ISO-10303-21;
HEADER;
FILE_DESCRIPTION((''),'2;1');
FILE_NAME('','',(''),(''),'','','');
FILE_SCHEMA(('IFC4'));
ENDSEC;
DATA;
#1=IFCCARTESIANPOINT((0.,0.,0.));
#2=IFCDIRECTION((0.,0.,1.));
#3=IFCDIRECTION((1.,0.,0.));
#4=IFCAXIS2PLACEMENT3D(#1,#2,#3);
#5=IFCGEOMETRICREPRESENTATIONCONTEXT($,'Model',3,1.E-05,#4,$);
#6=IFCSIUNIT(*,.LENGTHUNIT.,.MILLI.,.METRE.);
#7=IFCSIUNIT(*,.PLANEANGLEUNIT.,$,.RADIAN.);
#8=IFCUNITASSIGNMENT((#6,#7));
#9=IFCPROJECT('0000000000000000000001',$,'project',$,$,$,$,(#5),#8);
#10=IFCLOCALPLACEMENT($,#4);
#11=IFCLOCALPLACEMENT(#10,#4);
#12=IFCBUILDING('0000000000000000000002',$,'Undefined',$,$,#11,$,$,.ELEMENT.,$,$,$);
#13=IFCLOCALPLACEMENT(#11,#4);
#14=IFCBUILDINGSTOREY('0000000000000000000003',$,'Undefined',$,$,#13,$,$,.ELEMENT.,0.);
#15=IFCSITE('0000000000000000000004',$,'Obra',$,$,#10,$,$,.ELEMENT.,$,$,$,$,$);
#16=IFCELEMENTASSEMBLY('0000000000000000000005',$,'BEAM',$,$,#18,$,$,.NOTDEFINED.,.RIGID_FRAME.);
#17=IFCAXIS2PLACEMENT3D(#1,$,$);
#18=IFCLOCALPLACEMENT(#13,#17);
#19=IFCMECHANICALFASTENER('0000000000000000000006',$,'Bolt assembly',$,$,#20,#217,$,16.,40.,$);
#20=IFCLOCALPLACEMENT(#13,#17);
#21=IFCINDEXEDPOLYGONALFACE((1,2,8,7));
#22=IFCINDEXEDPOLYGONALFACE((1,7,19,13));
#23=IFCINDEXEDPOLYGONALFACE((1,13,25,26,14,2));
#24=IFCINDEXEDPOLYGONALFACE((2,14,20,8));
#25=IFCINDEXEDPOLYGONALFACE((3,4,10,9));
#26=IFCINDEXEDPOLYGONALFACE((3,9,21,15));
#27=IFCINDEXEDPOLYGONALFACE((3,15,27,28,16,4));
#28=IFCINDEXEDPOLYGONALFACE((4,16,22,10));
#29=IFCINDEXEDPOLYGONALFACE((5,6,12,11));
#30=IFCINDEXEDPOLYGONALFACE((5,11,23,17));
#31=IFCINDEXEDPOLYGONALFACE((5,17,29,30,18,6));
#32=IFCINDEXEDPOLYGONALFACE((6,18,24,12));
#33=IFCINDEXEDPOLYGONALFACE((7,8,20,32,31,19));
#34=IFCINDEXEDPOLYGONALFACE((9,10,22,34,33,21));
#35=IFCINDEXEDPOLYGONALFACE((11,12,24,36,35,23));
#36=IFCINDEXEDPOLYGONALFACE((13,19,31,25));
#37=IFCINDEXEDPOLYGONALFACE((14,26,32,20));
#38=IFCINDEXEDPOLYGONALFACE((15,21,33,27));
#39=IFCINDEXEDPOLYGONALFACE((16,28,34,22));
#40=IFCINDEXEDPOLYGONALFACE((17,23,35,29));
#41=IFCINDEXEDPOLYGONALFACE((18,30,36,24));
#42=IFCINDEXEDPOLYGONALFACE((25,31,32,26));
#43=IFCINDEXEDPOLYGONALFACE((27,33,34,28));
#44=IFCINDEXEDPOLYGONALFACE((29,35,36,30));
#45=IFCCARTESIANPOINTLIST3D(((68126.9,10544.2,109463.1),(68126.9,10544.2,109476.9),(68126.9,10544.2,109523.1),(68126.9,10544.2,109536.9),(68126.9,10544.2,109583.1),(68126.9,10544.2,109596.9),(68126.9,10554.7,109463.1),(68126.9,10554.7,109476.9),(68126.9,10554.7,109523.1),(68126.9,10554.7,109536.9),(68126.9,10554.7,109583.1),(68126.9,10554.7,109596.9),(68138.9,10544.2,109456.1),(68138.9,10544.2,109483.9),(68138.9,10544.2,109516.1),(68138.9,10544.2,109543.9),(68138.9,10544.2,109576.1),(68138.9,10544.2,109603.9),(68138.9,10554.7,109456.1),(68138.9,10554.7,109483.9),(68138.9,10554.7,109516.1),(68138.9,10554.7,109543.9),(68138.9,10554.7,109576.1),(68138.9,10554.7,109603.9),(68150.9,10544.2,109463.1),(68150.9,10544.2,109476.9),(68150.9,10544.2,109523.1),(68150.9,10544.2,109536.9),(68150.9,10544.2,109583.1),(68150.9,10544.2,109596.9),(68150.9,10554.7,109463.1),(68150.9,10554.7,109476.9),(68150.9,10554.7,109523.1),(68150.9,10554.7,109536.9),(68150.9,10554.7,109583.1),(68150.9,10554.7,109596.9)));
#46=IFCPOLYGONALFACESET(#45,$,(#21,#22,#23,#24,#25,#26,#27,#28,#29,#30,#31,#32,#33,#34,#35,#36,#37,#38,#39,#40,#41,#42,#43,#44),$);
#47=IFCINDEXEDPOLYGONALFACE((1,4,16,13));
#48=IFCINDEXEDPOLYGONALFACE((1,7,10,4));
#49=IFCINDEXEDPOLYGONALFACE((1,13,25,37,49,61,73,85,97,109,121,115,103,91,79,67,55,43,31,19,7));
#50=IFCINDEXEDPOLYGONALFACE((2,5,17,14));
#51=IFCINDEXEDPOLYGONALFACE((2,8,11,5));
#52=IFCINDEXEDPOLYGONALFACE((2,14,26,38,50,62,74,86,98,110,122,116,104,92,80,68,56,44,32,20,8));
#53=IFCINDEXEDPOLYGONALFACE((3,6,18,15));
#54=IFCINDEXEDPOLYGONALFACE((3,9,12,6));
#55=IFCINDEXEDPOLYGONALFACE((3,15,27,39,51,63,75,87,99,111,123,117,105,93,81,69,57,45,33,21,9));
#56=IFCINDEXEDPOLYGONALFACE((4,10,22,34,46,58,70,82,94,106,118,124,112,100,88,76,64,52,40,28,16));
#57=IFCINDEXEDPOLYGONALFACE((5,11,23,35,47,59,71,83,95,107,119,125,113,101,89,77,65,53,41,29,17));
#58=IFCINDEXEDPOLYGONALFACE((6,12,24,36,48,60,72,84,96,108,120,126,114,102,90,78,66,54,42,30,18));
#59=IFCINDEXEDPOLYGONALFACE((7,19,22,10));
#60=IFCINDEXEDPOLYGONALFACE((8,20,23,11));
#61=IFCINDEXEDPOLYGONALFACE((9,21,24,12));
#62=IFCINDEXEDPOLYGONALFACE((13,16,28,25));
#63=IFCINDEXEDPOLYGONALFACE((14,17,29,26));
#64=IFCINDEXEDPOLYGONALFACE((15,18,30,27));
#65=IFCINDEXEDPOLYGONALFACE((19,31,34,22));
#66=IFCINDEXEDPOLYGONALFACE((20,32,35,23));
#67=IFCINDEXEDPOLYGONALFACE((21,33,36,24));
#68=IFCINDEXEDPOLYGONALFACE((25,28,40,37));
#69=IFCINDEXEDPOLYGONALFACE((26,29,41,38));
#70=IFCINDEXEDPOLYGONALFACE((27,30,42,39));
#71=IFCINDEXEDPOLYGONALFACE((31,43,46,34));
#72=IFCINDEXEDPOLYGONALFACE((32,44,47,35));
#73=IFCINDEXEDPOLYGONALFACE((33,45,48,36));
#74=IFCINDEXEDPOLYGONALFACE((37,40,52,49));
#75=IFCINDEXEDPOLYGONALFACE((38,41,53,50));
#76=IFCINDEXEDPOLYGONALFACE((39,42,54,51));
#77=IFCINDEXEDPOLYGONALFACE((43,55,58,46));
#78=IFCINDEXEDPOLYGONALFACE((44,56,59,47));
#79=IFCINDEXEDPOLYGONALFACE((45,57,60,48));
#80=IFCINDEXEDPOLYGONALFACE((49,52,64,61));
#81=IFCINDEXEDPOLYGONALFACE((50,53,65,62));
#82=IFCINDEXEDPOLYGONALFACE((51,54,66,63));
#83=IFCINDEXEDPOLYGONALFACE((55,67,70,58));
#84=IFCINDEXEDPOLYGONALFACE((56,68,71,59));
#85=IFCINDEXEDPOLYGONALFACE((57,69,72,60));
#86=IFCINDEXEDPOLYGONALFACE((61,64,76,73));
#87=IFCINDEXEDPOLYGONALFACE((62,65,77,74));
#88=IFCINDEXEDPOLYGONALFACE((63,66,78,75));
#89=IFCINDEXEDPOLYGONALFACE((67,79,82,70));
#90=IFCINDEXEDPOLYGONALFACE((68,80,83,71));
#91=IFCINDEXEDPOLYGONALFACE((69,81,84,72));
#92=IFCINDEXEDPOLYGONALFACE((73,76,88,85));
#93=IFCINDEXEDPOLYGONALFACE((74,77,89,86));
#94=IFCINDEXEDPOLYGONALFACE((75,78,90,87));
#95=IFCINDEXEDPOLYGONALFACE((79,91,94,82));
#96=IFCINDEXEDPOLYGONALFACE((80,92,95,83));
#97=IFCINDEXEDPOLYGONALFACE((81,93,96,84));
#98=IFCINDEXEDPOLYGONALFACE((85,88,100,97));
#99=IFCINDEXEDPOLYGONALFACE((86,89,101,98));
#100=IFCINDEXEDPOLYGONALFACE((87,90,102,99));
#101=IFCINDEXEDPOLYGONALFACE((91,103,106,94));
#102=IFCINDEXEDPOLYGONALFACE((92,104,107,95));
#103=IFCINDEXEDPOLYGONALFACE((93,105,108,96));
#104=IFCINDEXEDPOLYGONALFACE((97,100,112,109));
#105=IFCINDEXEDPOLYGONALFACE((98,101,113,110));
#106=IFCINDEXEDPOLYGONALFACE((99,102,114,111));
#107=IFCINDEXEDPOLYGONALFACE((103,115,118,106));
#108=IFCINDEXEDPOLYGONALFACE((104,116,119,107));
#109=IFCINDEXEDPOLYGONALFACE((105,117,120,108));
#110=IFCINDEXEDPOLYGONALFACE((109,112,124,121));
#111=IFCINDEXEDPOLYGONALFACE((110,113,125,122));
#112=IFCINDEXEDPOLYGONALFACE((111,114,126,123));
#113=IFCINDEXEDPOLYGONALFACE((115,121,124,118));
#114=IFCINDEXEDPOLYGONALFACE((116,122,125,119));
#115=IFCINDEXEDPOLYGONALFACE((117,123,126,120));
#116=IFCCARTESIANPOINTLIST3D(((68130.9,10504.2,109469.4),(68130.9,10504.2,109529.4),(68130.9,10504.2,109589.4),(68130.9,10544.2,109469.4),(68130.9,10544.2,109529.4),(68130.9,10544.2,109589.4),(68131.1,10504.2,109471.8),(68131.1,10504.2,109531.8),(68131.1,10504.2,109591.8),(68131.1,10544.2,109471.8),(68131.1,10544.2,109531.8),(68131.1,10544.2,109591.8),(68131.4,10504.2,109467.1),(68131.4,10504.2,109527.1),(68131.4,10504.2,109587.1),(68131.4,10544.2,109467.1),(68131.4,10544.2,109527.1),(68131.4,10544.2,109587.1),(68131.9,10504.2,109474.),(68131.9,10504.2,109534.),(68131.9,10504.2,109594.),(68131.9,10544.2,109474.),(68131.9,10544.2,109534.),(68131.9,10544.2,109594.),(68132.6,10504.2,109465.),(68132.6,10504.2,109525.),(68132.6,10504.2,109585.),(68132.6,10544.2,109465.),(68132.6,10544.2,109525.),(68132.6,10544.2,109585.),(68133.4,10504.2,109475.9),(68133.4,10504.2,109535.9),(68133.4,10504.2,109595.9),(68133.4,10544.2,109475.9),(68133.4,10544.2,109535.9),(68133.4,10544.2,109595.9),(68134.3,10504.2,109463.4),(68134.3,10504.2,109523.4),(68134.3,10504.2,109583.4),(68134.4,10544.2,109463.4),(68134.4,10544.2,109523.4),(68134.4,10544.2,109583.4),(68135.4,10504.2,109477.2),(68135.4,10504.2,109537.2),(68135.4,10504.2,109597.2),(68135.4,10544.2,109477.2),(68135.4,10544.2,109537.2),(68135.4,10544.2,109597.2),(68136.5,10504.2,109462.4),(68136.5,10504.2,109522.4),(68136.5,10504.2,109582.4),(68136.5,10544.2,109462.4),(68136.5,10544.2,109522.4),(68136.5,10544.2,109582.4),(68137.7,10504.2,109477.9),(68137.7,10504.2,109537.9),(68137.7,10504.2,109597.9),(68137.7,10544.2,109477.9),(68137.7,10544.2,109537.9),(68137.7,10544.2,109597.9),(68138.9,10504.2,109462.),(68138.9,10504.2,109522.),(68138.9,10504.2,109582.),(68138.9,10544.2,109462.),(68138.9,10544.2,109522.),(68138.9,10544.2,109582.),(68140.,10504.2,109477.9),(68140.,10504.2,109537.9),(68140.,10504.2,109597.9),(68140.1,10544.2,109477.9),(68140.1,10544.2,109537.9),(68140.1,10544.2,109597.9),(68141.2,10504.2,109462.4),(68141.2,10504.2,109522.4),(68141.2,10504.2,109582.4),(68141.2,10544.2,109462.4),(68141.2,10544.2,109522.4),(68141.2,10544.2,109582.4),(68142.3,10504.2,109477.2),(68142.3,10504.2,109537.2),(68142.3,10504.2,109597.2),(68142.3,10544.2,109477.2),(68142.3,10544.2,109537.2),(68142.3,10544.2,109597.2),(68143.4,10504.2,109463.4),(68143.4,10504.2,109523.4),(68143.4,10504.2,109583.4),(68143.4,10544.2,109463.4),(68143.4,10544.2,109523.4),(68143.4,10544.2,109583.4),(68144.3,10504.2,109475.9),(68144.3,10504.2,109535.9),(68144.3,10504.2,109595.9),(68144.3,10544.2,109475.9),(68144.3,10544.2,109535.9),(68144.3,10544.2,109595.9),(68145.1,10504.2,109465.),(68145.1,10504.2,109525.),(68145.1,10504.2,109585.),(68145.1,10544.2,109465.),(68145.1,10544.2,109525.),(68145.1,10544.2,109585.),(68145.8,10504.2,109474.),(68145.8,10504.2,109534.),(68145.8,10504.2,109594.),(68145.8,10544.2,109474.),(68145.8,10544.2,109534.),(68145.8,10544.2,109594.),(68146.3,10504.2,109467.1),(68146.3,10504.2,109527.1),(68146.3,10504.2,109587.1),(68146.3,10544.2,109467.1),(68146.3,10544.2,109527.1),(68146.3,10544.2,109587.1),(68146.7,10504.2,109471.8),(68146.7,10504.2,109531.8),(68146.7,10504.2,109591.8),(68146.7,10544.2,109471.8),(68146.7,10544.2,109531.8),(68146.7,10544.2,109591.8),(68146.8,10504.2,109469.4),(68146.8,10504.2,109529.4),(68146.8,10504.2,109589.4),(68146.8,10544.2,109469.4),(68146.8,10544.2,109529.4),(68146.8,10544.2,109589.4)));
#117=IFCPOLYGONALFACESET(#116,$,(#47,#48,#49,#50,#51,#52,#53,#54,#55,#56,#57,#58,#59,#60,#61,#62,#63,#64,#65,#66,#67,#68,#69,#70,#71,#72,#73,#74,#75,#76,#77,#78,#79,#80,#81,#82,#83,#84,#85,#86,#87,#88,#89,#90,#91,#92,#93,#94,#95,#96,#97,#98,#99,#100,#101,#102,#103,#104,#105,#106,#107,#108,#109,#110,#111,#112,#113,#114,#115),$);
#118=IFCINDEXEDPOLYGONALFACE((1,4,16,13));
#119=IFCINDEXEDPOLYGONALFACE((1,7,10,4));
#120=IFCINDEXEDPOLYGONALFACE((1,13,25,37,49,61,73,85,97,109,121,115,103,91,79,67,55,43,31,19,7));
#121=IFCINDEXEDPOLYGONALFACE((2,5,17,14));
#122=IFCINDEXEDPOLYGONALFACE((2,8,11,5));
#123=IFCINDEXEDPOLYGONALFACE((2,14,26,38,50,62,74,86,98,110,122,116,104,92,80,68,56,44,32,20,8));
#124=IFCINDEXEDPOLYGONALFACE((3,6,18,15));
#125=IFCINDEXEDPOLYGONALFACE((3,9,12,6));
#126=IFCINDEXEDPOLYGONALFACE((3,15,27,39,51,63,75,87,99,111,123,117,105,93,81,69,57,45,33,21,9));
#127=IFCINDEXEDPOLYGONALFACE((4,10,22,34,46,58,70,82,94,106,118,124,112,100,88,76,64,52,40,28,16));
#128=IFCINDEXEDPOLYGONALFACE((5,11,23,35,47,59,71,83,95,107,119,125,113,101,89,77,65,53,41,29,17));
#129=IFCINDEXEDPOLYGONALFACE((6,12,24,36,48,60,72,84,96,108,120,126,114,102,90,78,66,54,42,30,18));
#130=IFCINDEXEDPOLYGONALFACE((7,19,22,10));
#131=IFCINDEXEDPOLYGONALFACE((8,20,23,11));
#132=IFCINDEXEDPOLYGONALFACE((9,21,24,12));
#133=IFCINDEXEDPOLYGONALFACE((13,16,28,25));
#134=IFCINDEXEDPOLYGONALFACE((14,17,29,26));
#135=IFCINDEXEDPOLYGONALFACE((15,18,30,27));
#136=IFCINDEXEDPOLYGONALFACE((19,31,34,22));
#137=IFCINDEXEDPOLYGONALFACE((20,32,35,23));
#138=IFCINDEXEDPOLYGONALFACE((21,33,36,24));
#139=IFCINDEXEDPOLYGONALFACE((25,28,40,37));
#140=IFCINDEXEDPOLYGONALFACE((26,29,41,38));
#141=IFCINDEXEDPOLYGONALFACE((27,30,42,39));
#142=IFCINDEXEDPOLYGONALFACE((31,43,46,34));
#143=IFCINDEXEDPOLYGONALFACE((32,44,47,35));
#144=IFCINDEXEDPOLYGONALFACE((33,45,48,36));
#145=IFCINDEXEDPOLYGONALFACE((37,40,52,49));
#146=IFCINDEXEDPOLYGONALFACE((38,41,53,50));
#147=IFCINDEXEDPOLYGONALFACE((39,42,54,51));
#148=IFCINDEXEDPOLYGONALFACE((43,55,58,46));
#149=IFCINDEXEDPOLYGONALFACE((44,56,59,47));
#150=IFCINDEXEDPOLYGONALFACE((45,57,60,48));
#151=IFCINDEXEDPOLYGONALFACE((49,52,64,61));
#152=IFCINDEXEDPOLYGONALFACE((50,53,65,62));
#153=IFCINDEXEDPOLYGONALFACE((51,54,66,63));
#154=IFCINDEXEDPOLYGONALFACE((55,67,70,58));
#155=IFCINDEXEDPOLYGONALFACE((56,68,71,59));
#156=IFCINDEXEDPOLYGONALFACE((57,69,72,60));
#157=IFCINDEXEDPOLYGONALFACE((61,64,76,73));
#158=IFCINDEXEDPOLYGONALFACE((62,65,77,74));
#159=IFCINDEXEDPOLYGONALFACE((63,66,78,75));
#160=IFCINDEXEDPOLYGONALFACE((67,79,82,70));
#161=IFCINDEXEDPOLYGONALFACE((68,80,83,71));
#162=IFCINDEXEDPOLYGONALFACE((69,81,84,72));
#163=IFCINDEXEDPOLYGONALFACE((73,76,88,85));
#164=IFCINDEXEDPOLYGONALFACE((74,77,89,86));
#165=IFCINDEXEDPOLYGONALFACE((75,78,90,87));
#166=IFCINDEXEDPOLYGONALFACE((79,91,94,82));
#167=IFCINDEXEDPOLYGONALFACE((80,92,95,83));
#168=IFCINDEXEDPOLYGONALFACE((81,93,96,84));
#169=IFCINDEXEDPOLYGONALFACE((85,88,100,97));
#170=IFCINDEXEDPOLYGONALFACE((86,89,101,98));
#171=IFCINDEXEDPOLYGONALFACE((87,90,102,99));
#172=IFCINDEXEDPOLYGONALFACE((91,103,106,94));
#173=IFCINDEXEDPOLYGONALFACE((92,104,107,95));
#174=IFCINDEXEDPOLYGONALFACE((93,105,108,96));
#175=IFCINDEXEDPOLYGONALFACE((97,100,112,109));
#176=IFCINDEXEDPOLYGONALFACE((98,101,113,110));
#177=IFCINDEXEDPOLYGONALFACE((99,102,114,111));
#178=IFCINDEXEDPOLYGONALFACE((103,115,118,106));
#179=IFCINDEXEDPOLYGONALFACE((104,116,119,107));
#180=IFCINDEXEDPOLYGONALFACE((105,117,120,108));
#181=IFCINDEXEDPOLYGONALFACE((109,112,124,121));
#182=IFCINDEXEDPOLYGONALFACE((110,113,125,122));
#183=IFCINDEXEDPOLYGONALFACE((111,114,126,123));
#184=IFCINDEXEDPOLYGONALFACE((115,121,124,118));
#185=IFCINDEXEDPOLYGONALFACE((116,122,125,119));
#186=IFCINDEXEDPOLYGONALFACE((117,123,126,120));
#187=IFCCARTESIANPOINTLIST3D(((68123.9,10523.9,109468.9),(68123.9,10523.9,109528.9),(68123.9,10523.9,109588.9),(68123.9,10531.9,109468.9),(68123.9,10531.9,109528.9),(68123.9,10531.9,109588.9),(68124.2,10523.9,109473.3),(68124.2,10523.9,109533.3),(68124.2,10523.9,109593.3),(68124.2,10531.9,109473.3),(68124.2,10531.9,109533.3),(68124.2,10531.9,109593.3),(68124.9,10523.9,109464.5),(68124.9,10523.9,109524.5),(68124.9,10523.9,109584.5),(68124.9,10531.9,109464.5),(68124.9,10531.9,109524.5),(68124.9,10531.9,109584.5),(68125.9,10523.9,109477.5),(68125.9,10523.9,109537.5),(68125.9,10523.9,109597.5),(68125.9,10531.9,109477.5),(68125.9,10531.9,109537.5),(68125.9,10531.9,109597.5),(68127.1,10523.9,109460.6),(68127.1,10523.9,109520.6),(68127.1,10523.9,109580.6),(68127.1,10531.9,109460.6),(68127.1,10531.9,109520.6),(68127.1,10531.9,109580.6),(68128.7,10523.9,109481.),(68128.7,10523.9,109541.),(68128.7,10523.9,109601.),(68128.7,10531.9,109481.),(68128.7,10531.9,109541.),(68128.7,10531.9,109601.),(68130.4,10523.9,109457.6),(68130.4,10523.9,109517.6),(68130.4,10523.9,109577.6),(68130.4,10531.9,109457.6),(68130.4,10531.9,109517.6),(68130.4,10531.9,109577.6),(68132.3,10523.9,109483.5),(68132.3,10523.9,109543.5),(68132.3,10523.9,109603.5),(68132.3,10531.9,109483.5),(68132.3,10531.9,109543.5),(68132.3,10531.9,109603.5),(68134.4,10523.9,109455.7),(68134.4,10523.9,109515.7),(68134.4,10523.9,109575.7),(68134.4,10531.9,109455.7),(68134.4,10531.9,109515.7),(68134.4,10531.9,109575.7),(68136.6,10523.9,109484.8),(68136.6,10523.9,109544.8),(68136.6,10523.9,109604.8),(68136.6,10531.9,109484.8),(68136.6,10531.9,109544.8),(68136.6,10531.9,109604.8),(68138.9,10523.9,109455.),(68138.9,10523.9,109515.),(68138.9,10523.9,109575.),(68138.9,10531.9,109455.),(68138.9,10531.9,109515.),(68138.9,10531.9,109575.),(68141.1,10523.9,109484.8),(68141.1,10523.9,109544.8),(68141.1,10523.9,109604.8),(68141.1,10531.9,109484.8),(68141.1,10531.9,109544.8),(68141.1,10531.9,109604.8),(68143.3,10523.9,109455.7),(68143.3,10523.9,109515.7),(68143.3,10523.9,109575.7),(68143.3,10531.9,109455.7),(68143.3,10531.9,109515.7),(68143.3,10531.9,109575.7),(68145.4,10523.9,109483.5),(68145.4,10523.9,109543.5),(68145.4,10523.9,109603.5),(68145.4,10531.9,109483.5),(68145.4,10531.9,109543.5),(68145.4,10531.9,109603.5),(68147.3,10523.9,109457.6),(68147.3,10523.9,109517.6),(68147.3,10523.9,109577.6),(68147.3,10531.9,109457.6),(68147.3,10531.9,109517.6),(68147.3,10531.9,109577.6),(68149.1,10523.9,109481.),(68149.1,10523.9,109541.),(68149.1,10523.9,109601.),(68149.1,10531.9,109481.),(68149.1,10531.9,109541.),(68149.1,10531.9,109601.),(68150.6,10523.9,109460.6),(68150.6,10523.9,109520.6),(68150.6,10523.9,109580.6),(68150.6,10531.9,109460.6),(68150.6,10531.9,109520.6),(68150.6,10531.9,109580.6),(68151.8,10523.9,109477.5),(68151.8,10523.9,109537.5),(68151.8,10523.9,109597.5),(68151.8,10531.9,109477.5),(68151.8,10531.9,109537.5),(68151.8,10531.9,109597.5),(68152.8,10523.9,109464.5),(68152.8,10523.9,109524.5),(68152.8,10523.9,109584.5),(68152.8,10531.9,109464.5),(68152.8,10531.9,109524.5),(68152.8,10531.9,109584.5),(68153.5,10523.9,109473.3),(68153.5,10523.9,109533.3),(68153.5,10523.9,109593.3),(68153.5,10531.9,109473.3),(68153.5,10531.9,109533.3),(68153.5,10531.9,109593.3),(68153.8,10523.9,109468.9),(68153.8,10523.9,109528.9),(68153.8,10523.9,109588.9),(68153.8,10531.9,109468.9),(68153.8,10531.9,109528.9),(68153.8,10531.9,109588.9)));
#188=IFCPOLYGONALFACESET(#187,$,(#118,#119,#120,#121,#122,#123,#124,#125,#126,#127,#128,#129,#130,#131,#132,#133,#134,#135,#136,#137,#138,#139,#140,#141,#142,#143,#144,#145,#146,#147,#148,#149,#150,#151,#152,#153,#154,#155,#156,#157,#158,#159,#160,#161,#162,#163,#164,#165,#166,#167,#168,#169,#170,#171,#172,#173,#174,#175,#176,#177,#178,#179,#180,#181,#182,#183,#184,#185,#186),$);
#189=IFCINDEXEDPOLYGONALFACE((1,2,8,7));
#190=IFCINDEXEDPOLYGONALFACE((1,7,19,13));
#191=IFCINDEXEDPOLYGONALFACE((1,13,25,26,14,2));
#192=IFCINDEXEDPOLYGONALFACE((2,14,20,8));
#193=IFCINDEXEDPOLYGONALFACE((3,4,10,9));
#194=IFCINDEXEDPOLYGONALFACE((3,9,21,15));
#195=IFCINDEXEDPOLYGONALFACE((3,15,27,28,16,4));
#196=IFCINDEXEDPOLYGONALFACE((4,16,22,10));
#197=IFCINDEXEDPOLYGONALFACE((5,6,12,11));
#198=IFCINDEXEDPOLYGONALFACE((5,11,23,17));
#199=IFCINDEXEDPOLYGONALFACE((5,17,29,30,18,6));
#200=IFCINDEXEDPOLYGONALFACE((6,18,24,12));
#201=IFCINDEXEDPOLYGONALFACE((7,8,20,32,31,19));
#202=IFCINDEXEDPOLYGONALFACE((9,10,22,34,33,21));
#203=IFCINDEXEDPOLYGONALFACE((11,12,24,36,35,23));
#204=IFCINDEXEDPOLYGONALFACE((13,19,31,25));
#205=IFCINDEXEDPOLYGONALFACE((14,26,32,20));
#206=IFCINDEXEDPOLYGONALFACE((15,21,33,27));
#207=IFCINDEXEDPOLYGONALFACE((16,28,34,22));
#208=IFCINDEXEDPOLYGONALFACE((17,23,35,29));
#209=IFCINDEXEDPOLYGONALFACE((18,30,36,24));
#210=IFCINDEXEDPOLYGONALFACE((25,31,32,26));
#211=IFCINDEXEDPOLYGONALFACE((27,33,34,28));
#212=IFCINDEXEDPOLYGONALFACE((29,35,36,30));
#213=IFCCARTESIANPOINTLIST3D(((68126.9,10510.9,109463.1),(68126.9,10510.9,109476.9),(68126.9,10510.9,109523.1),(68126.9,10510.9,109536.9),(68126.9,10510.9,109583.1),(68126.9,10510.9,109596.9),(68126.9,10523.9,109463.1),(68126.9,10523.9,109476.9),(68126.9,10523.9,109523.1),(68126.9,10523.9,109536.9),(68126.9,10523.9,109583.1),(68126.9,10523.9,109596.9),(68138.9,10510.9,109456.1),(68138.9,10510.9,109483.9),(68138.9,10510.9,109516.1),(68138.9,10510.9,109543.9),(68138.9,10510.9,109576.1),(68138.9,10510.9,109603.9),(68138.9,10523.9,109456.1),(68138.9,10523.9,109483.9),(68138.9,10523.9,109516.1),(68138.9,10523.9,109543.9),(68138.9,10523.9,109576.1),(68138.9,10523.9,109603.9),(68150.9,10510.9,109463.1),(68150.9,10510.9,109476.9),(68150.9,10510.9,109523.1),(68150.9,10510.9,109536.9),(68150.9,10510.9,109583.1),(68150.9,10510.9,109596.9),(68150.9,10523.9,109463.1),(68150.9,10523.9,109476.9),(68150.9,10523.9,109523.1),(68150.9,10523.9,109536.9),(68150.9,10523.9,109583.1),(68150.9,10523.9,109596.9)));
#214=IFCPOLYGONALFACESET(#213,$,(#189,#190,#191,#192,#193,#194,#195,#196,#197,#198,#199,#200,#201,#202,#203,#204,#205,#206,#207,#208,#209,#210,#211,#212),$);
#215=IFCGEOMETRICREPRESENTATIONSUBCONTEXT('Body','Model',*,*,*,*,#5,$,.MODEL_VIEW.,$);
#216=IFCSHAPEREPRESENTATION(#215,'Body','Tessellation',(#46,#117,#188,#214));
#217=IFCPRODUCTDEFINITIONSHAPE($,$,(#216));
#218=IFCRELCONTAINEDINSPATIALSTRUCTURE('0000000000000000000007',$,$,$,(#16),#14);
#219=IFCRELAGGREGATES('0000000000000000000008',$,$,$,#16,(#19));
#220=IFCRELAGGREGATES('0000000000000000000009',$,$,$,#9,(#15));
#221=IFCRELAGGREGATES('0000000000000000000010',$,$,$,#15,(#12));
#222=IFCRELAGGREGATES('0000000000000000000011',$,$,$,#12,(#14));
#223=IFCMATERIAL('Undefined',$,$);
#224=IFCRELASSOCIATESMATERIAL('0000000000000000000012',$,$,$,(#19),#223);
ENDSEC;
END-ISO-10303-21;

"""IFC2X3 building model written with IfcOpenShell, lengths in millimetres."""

from ifc_helpers import new_model, si_unit, frame, origin_with_axes, origin_2d_with_axis, place, context, subcontext, project, spatial, polyline, circle, outline, extrude, source, transform, mapped, material, element, aggregate, save


model = new_model("IFC2X3")

# Units and contexts
model_context = context("Model", 3, precision=1e-05, world=origin_with_axes())
body_context = subcontext(model_context, "Body", "Model", "MODEL_VIEW")
ifc_project = project(units=[si_unit("LENGTHUNIT", "METRE", prefix="MILLI"), si_unit("PLANEANGLEUNIT", "RADIAN")], contexts=[model_context])

# Site, building, storey
site_placement = place(None, origin_with_axes())
site = spatial("IfcSite", under=ifc_project, at=site_placement, Name="Obra", CompositionType="ELEMENT")
building_placement = place(site_placement, origin_with_axes())
building = spatial("IfcBuilding", under=site, at=building_placement, Name="Undefined", CompositionType="ELEMENT")
storey_placement = place(building_placement, origin_with_axes())
storey = spatial("IfcBuildingStorey", under=building, at=storey_placement, Name="Undefined", CompositionType="ELEMENT", Elevation=0.0)

# Shared definitions
ifc_material_1 = material(Name="Undefined")

# Shared definitions
shared_shape_1 = source(origin_with_axes(), body_context, "Body", "SweptSolid", [
    extrude(outline(polyline([(13.9, 0.0), (6.9, 12.0), (-6.9, 12.0), (-13.9, 0.0), (-6.9, -12.0), (6.9, -12.0), (13.9, 0.0)])), frame((0.0, -19.7, 0.0), z_axis=(0.0, 1.0, 0.0), x_axis=(1.0, 0.0, 0.0)), (0.0, 0.0, 1.0), 10.6),
    extrude(circle(Radius=8.0, at=origin_2d_with_axis()), frame((0.0, -9.1, 0.0), z_axis=(0.0, 1.0, 0.0), x_axis=(1.0, 0.0, 0.0)), (0.0, 0.0, 1.0), 40.0),
    extrude(circle(Radius=15.0, at=origin_2d_with_axis()), frame((0.0, 3.1, 0.0), z_axis=(0.0, 1.0, 0.0), x_axis=(1.0, 0.0, 0.0)), (0.0, 0.0, 1.0), 8.0),
    extrude(outline(polyline([(13.9, 0.0), (6.9, 12.0), (-6.9, 12.0), (-13.9, 0.0), (-6.9, -12.0), (6.9, -12.0), (13.9, 0.0)])), frame((0.0, 11.1, 0.0), z_axis=(0.0, 1.0, 0.0), x_axis=(1.0, 0.0, 0.0)), (0.0, 0.0, 1.0), 13.0),
])

# Element assembly, mechanical fastener
assembly_1_placement = place(storey_placement, origin_with_axes())
assembly_1 = element("IfcElementAssembly", 1, at=assembly_1_placement, inside=storey, Name="BEAM", AssemblyPlace="NOTDEFINED", PredefinedType="RIGID_FRAME")
mechanical_fastener_1_placement = place(assembly_1_placement, frame((68188.9, 10535.0, 109650.0), z_axis=(-1.0, 0.000126, 0.0), x_axis=(0.0, 0.0, -1.0)))
mechanical_fastener_1 = element("IfcMechanicalFastener", 2, at=mechanical_fastener_1_placement, material=ifc_material_1, Name="Bolt assembly", NominalDiameter=16.0, NominalLength=40.0, context=body_context, shape_type="MappedRepresentation", body=[
    mapped(shared_shape_1, transform((60.0, 0.0, 50.0))),
    mapped(shared_shape_1, transform((120.0, 0.0, 50.0))),
    mapped(shared_shape_1, transform((180.0, 0.0, 50.0))),
])
aggregate(assembly_1, [mechanical_fastener_1])

save(model, "model.ifc")
